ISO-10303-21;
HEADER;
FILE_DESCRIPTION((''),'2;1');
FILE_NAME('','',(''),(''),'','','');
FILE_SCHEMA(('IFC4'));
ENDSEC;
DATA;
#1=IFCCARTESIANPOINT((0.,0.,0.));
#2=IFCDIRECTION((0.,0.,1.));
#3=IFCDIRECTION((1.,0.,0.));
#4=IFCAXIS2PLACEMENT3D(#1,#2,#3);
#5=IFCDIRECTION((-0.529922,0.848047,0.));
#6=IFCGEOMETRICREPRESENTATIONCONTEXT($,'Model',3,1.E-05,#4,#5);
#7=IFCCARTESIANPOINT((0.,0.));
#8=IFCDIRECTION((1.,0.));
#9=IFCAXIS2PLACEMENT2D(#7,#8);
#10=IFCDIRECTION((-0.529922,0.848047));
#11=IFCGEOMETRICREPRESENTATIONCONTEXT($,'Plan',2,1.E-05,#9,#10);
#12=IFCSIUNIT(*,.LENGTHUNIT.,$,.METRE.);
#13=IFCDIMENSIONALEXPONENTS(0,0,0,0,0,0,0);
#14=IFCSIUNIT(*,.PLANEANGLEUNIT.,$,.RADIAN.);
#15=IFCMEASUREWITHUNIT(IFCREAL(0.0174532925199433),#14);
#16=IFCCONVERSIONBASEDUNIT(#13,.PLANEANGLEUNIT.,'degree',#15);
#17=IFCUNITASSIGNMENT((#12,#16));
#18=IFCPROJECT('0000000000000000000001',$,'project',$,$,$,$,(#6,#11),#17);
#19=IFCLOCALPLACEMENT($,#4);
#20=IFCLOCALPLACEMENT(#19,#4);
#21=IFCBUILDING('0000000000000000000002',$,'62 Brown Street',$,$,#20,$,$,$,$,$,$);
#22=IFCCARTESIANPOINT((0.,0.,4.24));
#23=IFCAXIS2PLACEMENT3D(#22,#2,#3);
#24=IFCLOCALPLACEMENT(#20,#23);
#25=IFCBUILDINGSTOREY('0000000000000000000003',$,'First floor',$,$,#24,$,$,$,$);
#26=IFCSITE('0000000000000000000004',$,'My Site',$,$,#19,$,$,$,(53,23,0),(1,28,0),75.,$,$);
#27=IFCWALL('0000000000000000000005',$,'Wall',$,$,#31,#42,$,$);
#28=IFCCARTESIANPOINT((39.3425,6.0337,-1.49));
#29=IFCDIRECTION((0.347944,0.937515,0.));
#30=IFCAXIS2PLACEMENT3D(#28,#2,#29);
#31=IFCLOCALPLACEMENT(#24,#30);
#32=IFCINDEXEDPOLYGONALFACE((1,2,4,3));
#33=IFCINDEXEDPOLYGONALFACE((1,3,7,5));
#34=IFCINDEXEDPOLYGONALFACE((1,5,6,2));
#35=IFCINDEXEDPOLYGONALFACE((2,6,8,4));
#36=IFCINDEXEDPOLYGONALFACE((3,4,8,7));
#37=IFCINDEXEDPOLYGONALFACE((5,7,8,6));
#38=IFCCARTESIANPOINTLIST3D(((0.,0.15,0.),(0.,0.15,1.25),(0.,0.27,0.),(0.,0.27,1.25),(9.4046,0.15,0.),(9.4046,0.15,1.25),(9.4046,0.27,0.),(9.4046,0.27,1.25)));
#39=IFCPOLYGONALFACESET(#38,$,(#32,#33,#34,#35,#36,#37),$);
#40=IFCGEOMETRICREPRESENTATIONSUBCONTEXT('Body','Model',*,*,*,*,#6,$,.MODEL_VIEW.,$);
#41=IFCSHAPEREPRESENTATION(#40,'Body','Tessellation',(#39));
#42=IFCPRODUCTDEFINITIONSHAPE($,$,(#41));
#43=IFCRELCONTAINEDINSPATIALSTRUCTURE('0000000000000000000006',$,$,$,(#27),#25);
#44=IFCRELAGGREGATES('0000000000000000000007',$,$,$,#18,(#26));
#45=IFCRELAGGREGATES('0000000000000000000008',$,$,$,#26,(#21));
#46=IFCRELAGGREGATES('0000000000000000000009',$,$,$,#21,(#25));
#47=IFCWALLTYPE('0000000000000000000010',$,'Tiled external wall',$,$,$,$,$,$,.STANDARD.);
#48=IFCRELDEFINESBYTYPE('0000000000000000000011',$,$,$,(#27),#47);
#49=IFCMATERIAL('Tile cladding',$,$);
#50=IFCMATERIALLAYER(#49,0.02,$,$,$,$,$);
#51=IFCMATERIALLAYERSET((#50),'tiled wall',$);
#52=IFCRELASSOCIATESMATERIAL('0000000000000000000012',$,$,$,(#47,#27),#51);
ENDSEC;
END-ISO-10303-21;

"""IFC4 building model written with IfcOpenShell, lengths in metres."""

from ifc_helpers import new_model, entity, si_unit, converted_unit, direction, frame, origin_with_axes, origin_2d_with_axis, place, context, subcontext, project, spatial, indexed_curve, outline, extrude, material, layer, layer_set, layer_usage, type_object, element, save


model = new_model("IFC4")

# Units and contexts
model_context = context("Model", 3, precision=1e-05, world=origin_with_axes(), true_north=direction((-0.529922, 0.848047, 0.0)))
plan_context = context("Plan", 2, precision=1e-05, world=origin_2d_with_axis(), true_north=direction((-0.529922, 0.848047)))
body_context_1 = subcontext(model_context, "Body", "Model", "MODEL_VIEW")
ifc_project = project(units=[si_unit("LENGTHUNIT", "METRE"), converted_unit("PLANEANGLEUNIT", "degree", entity("IfcReal", 0.0174532925199433), si_unit("PLANEANGLEUNIT", "RADIAN"), dimensions=[0, 0, 0, 0, 0, 0, 0])], contexts=[model_context, plan_context])

# Site, building, storey
site_placement = place(None, origin_with_axes())
site = spatial("IfcSite", under=ifc_project, at=site_placement, Name="My Site", RefLatitude=(53, 23, 0), RefLongitude=(1, 28, 0), RefElevation=75.0)
building_placement = place(site_placement, origin_with_axes())
building = spatial("IfcBuilding", under=site, at=building_placement, Name="62 Brown Street")
storey_placement = place(building_placement, frame((0.0, 0.0, 4.24), z_axis=(0.0, 0.0, 1.0), x_axis=(1.0, 0.0, 0.0)))
storey = spatial("IfcBuildingStorey", under=building, at=storey_placement, Name="First floor")

# Wall
ifc_material_1 = material(Name="Tile cladding")
ifc_layer_1 = layer(ifc_material_1, 0.02)
ifc_layer_set_1 = layer_set([ifc_layer_1], Name="tiled wall")
ifc_layer_usage_1 = layer_usage(ifc_layer_set_1, "AXIS2", "POSITIVE", 0.15)
wall_type_1 = type_object("IfcWallType", Name="Tiled external wall", PredefinedType="STANDARD", material=ifc_layer_set_1)
wall_1_placement = place(storey_placement, frame((39.3425, 6.0337, -1.49), z_axis=(0.0, 0.0, 1.0), x_axis=(0.347944, 0.937515, 0.0)))
element("IfcWall", 1, at=wall_1_placement, inside=storey, type_object=wall_type_1, material=ifc_layer_usage_1, Name="Wall", context=body_context_1, shape_type="SweptSolid", body=[
    extrude(outline(indexed_curve([(0.0, 0.0), (0.0, 0.12), (9.4046, 0.12), (9.4046, 0.0), (0.0, 0.0)], self_intersect=False)), frame((0.0, 0.15, 0.0), z_axis=(0.0, 0.0, 1.0), x_axis=(1.0, 0.0, 0.0)), (0.0, 0.0, 1.0), 1.25),
])

save(model, "model.ifc")
